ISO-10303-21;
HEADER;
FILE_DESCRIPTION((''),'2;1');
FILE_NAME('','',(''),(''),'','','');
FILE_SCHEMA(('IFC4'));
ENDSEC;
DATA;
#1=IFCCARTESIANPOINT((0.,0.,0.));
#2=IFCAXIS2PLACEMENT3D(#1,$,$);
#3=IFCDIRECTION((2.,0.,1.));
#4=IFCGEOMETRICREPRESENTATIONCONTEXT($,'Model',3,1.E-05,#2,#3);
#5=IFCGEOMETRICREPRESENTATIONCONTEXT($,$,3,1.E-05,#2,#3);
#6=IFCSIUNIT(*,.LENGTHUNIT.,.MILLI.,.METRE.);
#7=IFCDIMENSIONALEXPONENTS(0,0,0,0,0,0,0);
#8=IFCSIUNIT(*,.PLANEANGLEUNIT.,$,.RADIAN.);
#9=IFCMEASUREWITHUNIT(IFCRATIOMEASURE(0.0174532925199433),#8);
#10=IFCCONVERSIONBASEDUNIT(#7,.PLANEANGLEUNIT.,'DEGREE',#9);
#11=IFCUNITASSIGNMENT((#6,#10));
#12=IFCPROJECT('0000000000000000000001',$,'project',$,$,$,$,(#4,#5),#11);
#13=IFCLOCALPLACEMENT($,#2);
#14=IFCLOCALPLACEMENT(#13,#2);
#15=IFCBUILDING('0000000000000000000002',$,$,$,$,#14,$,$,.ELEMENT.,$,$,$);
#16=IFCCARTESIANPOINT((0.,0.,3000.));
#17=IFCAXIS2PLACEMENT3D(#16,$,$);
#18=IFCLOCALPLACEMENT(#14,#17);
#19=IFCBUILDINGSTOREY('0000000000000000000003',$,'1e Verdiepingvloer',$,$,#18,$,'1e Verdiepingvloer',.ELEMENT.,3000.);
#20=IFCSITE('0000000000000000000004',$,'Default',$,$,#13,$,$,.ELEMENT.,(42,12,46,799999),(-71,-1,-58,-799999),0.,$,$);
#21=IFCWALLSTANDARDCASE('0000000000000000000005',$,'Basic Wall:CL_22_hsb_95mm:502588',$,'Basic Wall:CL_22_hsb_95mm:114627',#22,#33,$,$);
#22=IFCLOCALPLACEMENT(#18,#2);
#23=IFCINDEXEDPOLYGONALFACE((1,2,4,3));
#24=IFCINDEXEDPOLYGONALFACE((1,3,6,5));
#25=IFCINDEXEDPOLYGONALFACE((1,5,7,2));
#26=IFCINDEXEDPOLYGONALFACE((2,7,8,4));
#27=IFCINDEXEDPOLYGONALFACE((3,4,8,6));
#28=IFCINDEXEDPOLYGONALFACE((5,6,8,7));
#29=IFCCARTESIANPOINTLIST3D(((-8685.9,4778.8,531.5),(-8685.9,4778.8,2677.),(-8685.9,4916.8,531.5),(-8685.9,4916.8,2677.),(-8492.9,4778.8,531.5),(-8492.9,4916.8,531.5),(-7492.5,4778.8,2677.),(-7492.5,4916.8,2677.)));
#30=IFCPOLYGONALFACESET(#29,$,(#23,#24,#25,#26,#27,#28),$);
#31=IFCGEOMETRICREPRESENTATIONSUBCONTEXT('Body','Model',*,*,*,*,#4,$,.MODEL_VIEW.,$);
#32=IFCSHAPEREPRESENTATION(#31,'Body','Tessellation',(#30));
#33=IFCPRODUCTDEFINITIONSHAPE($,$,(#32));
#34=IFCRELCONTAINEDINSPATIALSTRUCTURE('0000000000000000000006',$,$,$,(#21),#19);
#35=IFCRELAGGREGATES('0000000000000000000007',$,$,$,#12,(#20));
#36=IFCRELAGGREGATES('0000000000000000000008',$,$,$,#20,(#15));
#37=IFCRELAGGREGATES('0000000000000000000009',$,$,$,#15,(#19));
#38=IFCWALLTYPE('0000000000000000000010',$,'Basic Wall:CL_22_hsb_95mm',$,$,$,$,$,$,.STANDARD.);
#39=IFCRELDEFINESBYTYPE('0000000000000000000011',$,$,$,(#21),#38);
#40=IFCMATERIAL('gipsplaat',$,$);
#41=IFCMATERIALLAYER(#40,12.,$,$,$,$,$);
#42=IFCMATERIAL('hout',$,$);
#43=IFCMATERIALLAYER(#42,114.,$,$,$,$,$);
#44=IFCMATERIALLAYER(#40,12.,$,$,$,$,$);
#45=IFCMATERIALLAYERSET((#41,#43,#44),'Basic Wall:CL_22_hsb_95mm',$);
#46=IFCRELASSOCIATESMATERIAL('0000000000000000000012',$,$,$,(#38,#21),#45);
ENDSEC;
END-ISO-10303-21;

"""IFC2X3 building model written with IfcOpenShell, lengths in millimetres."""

from ifc_helpers import new_model, entity, si_unit, converted_unit, direction, frame, frame_2d, origin, place, context, subcontext, project, spatial, rectangle, extrude, clip, halfspace, material, layer, layer_set, layer_usage, type_object, element, save


model = new_model("IFC2X3")

# Units and contexts
model_context = context("Model", 3, precision=1e-05, world=origin(), true_north=direction((2.0, 0.0, 1.0)))
context_of_model = context(None, 3, precision=1e-05, world=origin(), true_north=direction((2.0, 0.0, 1.0)))
body_context = subcontext(model_context, "Body", "Model", "MODEL_VIEW")
ifc_project = project(units=[si_unit("LENGTHUNIT", "METRE", prefix="MILLI"), converted_unit("PLANEANGLEUNIT", "DEGREE", entity("IfcRatioMeasure", 0.0174532925199433), si_unit("PLANEANGLEUNIT", "RADIAN"), dimensions=[0, 0, 0, 0, 0, 0, 0])], contexts=[model_context, context_of_model])

# Site, building, storey
site_placement = place(None, origin())
site = spatial("IfcSite", under=ifc_project, at=site_placement, Name="Default", CompositionType="ELEMENT", RefLatitude=(42, 12, 46, 799999), RefLongitude=(-71, -1, -58, -799999), RefElevation=0.0)
building_placement = place(site_placement, origin())
building = spatial("IfcBuilding", under=site, at=building_placement, CompositionType="ELEMENT")
storey_placement = place(building_placement, frame((0.0, 0.0, 3000.0)))
storey = spatial("IfcBuildingStorey", under=building, at=storey_placement, Name="1e Verdiepingvloer", LongName="1e Verdiepingvloer", CompositionType="ELEMENT", Elevation=3000.0)

# Shared definitions
ifc_material_1 = material(Name="hout")

# Wall
ifc_material_2 = material(Name="gipsplaat")
ifc_layer_1 = layer(ifc_material_2, 12.0)
ifc_layer_2 = layer(ifc_material_1, 114.0)
ifc_layer_3 = layer(ifc_material_2, 12.0)
ifc_layer_set_1 = layer_set([ifc_layer_1, ifc_layer_2, ifc_layer_3], Name="Basic Wall:CL_22_hsb_95mm")
ifc_layer_usage_1 = layer_usage(ifc_layer_set_1, "AXIS2", "POSITIVE", -69.0)
wall_type_1 = type_object("IfcWallType", Name="Basic Wall:CL_22_hsb_95mm", PredefinedType="STANDARD", material=ifc_layer_set_1)
wall_1_placement = place(storey_placement, frame((-7492.5, 4847.8, 0.0), z_axis=(0.0, 0.0, 1.0), x_axis=(-1.0, 0.0, 0.0)))
element("IfcWallStandardCase", 1, at=wall_1_placement, inside=storey, type_object=wall_type_1, material=ifc_layer_usage_1, Name="Basic Wall:CL_22_hsb_95mm:502588", ObjectType="Basic Wall:CL_22_hsb_95mm:114627", context=body_context, shape_type="Clipping", body=[
    clip(clip(extrude(rectangle(XDim=1193.5, YDim=138.0, at=frame_2d((596.7, 0.0), x_axis=(-1.0, 0.0))), origin(), (0.0, 0.0, 1.0), 2677.0), halfspace(frame((1000.5, -69.0, 531.5), z_axis=(-0.906308, 0.0, -0.422618), x_axis=(0.0, 1.0, 0.0)), False)), halfspace(frame((1193.5, -69.0, 531.5), z_axis=(0.0, 0.0, -1.0), x_axis=(0.0, 1.0, 0.0)), False)),
])

save(model, "model.ifc")
